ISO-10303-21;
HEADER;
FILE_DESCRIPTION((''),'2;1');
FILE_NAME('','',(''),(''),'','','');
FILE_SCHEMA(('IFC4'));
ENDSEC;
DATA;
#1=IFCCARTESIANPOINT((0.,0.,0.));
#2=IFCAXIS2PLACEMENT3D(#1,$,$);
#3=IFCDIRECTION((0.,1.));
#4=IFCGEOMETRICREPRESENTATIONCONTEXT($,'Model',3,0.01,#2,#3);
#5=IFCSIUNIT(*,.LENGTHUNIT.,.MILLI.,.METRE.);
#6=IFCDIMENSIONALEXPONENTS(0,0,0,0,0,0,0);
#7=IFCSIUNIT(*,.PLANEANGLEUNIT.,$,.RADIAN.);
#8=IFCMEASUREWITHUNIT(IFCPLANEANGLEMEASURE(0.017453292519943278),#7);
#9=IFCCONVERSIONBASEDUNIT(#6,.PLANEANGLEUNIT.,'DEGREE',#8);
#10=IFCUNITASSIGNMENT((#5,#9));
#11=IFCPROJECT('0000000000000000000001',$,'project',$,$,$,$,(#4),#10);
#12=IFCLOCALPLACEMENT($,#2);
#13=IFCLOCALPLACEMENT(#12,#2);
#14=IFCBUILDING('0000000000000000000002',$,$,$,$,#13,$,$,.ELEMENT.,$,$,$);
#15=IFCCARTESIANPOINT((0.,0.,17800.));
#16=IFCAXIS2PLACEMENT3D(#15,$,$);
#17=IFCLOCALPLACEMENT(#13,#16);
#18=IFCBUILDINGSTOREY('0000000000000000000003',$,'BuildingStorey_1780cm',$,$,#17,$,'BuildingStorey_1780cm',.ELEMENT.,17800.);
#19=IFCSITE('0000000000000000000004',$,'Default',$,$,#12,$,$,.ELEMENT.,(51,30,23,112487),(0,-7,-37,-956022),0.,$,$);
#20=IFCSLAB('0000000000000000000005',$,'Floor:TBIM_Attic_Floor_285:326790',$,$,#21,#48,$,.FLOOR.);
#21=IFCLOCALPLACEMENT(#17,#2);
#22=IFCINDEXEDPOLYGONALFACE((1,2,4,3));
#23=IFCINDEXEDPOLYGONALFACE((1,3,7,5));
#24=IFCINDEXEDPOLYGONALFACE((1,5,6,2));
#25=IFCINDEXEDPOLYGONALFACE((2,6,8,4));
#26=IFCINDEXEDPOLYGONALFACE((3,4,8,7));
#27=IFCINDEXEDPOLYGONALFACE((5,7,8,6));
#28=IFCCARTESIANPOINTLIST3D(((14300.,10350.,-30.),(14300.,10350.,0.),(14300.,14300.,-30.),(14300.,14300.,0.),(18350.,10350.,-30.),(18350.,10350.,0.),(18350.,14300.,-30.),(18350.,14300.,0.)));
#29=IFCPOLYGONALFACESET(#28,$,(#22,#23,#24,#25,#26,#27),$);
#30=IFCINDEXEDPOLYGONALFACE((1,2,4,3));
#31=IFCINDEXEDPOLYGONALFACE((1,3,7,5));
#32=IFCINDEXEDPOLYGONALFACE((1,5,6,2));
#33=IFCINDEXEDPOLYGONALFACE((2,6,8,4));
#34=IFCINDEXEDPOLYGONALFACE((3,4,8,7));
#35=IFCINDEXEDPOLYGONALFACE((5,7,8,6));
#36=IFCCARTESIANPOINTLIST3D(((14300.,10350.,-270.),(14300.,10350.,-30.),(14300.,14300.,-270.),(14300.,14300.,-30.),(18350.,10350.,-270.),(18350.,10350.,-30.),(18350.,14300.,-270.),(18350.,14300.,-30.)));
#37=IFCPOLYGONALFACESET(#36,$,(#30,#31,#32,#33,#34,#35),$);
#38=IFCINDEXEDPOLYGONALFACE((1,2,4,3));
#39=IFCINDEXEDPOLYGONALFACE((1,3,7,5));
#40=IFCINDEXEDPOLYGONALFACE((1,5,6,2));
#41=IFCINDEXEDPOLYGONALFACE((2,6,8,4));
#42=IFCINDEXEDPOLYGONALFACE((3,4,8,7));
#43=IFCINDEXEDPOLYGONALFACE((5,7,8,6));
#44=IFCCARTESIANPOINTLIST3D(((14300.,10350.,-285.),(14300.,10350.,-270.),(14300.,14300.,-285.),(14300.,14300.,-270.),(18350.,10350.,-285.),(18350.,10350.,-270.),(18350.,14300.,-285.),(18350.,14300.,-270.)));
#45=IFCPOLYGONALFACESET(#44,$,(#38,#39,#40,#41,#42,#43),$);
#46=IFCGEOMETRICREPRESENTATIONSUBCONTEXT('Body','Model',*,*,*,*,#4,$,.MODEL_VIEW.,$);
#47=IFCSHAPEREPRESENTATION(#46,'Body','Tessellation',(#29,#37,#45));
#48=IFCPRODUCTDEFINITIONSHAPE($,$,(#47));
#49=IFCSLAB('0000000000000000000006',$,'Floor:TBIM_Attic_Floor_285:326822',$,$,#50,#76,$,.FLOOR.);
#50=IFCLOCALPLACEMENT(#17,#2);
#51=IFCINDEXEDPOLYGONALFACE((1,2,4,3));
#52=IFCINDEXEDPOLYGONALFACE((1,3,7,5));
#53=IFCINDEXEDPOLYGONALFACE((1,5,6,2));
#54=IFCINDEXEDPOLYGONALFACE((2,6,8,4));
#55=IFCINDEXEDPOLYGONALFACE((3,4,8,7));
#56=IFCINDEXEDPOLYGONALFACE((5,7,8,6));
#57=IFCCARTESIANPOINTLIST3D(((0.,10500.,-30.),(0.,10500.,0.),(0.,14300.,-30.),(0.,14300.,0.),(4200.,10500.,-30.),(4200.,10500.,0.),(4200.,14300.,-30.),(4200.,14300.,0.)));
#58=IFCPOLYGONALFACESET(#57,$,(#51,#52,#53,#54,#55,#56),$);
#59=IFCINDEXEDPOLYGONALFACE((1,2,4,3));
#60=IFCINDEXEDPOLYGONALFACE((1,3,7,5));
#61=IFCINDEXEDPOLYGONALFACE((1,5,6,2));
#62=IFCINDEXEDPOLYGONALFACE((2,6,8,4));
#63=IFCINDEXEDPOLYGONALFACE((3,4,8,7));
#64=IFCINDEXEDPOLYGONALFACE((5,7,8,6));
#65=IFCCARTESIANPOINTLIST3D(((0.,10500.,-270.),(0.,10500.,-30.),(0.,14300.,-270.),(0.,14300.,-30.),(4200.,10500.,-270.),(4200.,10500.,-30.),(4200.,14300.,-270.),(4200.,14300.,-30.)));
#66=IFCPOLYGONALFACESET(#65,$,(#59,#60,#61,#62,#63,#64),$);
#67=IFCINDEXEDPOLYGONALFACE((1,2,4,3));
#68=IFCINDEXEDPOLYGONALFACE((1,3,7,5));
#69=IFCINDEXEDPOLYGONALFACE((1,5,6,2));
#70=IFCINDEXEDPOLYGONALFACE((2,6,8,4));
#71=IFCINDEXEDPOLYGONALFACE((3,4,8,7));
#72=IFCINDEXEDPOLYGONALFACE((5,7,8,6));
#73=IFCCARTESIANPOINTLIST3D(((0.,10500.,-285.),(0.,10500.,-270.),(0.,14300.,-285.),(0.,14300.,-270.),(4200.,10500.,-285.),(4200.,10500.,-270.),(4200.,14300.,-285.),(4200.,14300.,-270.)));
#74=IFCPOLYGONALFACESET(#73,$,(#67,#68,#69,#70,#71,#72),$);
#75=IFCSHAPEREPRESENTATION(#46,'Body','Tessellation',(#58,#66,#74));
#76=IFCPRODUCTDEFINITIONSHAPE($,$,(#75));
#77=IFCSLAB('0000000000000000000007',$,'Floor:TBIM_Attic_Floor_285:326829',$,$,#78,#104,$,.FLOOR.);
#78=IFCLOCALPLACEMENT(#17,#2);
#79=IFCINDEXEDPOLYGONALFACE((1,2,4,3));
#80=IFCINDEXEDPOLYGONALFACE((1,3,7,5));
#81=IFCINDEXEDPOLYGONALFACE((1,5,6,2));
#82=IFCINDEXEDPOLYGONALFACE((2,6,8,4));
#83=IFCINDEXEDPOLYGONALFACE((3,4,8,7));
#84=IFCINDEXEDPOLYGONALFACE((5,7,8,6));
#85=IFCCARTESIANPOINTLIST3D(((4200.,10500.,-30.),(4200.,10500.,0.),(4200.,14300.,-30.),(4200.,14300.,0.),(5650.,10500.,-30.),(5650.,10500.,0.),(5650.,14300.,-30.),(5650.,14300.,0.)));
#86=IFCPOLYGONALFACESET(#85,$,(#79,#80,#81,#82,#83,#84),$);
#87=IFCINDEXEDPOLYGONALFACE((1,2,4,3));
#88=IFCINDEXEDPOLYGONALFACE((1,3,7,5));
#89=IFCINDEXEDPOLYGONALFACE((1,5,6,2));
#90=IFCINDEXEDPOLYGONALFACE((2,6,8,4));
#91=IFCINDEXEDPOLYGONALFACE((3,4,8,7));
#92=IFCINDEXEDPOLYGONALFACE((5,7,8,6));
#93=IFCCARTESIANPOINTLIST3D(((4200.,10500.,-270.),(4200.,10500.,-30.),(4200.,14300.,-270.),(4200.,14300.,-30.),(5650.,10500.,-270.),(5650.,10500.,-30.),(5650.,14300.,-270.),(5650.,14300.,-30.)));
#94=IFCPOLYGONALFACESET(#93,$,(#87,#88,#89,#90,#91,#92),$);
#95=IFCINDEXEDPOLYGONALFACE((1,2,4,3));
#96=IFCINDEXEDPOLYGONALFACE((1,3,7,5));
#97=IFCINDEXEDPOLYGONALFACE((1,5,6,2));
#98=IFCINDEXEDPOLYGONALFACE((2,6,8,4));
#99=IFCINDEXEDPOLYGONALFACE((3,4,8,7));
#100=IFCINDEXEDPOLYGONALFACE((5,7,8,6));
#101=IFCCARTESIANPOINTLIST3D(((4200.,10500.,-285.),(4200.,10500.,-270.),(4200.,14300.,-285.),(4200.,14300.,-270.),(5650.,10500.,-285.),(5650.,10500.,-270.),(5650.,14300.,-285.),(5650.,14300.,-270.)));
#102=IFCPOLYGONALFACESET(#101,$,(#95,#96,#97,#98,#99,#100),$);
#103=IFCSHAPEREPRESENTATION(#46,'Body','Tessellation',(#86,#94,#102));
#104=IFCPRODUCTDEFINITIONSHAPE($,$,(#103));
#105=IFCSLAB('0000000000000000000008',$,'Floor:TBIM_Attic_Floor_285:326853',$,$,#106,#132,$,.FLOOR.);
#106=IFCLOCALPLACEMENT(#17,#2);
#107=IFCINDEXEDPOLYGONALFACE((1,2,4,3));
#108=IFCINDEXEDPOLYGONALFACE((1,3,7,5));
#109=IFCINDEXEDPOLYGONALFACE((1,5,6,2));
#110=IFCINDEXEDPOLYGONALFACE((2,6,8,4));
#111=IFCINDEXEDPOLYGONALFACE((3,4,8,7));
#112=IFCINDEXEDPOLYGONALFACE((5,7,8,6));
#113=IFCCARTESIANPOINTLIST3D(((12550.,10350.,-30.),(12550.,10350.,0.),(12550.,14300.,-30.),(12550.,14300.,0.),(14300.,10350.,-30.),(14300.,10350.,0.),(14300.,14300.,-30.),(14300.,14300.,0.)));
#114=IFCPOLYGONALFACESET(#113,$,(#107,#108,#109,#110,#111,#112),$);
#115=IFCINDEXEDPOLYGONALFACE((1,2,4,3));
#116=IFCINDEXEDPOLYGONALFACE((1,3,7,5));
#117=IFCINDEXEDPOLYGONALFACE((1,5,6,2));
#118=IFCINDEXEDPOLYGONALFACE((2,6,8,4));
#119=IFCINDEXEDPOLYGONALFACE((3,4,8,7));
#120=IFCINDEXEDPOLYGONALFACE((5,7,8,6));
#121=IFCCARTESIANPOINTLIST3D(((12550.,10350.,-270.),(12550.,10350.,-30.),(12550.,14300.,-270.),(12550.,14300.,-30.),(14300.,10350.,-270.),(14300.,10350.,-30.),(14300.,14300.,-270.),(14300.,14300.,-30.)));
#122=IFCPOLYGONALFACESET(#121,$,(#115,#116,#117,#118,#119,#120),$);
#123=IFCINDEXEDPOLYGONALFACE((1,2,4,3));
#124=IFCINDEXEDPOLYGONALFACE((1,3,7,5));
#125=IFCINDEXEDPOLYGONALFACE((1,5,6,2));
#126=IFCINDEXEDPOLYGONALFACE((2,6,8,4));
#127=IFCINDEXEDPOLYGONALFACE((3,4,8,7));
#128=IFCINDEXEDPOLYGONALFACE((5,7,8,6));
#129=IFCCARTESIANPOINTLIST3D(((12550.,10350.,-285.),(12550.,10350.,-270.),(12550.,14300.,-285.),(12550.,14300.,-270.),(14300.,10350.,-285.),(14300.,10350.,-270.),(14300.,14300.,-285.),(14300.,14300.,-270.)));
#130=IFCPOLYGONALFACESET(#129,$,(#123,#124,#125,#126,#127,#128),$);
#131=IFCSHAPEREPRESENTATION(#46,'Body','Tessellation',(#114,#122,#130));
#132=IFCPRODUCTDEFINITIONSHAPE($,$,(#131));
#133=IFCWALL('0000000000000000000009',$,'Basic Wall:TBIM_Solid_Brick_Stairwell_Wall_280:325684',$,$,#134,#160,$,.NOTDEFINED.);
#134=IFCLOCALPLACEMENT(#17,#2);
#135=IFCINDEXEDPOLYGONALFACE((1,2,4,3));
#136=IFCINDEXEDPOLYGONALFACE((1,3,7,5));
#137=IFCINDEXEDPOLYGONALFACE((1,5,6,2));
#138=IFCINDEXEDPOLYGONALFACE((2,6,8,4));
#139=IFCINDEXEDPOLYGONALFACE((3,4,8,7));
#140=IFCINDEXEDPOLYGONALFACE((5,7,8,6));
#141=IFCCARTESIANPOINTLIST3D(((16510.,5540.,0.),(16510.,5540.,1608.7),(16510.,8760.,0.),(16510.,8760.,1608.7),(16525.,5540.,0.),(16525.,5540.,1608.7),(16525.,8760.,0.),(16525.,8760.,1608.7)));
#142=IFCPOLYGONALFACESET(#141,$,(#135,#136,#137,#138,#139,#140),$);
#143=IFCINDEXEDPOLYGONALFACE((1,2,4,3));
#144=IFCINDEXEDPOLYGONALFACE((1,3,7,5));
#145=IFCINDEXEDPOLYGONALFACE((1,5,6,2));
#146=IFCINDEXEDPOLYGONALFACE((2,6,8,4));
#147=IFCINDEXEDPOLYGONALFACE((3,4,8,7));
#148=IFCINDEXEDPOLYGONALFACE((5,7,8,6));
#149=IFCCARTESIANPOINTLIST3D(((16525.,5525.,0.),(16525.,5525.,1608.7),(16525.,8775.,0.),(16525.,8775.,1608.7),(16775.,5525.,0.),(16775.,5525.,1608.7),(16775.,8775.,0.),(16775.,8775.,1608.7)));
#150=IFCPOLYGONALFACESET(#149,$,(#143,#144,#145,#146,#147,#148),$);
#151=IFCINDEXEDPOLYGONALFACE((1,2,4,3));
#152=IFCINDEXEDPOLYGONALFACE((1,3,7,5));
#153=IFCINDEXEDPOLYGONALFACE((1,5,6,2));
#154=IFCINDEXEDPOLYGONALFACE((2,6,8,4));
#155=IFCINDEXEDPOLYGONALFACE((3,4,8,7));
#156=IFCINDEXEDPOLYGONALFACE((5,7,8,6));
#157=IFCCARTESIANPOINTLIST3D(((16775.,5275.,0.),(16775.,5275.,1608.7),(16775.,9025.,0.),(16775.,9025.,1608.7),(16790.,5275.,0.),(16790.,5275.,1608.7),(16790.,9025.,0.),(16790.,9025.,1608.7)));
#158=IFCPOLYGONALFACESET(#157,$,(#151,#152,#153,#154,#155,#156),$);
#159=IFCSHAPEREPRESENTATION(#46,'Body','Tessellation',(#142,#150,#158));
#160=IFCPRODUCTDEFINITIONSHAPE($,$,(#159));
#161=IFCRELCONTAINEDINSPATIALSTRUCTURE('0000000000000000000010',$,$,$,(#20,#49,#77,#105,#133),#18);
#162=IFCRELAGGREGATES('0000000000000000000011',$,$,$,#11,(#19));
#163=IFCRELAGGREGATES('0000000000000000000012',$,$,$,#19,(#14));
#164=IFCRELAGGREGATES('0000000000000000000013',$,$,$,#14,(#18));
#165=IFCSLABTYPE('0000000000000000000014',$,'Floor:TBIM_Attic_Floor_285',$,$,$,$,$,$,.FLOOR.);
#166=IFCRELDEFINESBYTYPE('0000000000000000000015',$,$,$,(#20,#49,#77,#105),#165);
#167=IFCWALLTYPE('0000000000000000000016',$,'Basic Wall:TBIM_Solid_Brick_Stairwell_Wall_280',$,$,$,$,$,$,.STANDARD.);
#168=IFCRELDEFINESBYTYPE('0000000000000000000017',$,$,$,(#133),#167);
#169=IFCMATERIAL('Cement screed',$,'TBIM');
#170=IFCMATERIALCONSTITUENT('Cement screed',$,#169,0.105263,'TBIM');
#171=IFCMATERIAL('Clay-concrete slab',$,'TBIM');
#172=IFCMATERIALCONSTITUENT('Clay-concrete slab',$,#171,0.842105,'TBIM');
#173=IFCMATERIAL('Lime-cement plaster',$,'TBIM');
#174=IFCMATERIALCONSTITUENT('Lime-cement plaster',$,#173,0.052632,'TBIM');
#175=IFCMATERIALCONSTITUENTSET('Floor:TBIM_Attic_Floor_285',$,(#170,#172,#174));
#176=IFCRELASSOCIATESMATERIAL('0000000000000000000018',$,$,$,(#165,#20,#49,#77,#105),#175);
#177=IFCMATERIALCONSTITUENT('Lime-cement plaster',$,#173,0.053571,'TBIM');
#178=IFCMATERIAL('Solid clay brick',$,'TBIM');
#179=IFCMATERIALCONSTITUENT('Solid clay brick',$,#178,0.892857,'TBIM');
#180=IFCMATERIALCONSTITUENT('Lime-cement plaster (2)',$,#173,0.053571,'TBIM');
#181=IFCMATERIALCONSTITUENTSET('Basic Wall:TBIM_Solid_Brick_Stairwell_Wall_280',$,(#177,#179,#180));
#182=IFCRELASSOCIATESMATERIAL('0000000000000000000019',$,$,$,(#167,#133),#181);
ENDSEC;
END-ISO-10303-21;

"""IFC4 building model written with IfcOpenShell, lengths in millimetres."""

from ifc_helpers import new_model, entity, si_unit, converted_unit, direction, frame, origin, place, context, subcontext, project, spatial, indexed_curve, outline, extrude, material, constituent, constituent_set, type_object, element, save


model = new_model("IFC4")

# Units and contexts
model_context = context("Model", 3, precision=0.01, world=origin(), true_north=direction((0.0, 1.0)))
body_context = subcontext(model_context, "Body", "Model", "MODEL_VIEW")
ifc_project = project(units=[si_unit("LENGTHUNIT", "METRE", prefix="MILLI"), converted_unit("PLANEANGLEUNIT", "DEGREE", entity("IfcPlaneAngleMeasure", 0.017453292519943278), si_unit("PLANEANGLEUNIT", "RADIAN"), dimensions=[0, 0, 0, 0, 0, 0, 0])], contexts=[model_context])

# Site, building, storey
site_placement = place(None, origin())
site = spatial("IfcSite", under=ifc_project, at=site_placement, Name="Default", CompositionType="ELEMENT", RefLatitude=(51, 30, 23, 112487), RefLongitude=(0, -7, -37, -956022), RefElevation=0.0)
building_placement = place(site_placement, origin())
building = spatial("IfcBuilding", under=site, at=building_placement, CompositionType="ELEMENT")
storey_placement = place(building_placement, frame((0.0, 0.0, 17800.0)))
storey = spatial("IfcBuildingStorey", under=building, at=storey_placement, Name="BuildingStorey_1780cm", LongName="BuildingStorey_1780cm", CompositionType="ELEMENT", Elevation=17800.0)

# Slabs
ifc_material_1 = material(Name="Cement screed", Category="TBIM")
ifc_material_2 = material(Name="Clay-concrete slab", Category="TBIM")
ifc_material_3 = material(Name="Lime-cement plaster", Category="TBIM")
ifc_constituent_1 = constituent(ifc_material_1, Name="Cement screed", Category="TBIM", fraction=0.105263)
ifc_constituent_2 = constituent(ifc_material_2, Name="Clay-concrete slab", Category="TBIM", fraction=0.842105)
ifc_constituent_3 = constituent(ifc_material_3, Name="Lime-cement plaster", Category="TBIM", fraction=0.052632)
ifc_constituent_set_1 = constituent_set(constituents=[ifc_constituent_1, ifc_constituent_2, ifc_constituent_3], Name="Floor:TBIM_Attic_Floor_285")
slab_type_1 = type_object("IfcSlabType", Name="Floor:TBIM_Attic_Floor_285", PredefinedType="FLOOR", material=ifc_constituent_set_1)
slab_1_placement = place(storey_placement, origin())
element("IfcSlab", 1, at=slab_1_placement, inside=storey, type_object=slab_type_1, material=ifc_constituent_set_1, Name="Floor:TBIM_Attic_Floor_285:326790", PredefinedType="FLOOR", context=body_context, shape_type="SweptSolid", body=[
    extrude(outline(indexed_curve([(-2025.0, -1975.0), (2025.0, -1975.0), (2025.0, 1975.0), (-2025.0, 1975.0), (-2025.0, -1975.0)], self_intersect=False)), frame((16325.0, 12325.0, -30.0), z_axis=(0.0, 0.0, 1.0), x_axis=(-1.0, 0.0, 0.0)), (0.0, 0.0, 1.0), 30.0),
    extrude(outline(indexed_curve([(-2025.0, -1975.0), (2025.0, -1975.0), (2025.0, 1975.0), (-2025.0, 1975.0), (-2025.0, -1975.0)], self_intersect=False)), frame((16325.0, 12325.0, -270.0), z_axis=(0.0, 0.0, 1.0), x_axis=(-1.0, 0.0, 0.0)), (0.0, 0.0, 1.0), 240.0),
    extrude(outline(indexed_curve([(-2025.0, -1975.0), (2025.0, -1975.0), (2025.0, 1975.0), (-2025.0, 1975.0), (-2025.0, -1975.0)], self_intersect=False)), frame((16325.0, 12325.0, -285.0), z_axis=(0.0, 0.0, 1.0), x_axis=(-1.0, 0.0, 0.0)), (0.0, 0.0, 1.0), 15.0),
])
slab_2_placement = place(storey_placement, origin())
element("IfcSlab", 2, at=slab_2_placement, inside=storey, type_object=slab_type_1, material=ifc_constituent_set_1, Name="Floor:TBIM_Attic_Floor_285:326822", PredefinedType="FLOOR", context=body_context, shape_type="SweptSolid", body=[
    extrude(outline(indexed_curve([(-2100.0, -1900.0), (2100.0, -1900.0), (2100.0, 1900.0), (-2100.0, 1900.0), (-2100.0, -1900.0)], self_intersect=False)), frame((2100.0, 12400.0, -30.0), z_axis=(0.0, 0.0, 1.0), x_axis=(-1.0, 0.0, 0.0)), (0.0, 0.0, 1.0), 30.0),
    extrude(outline(indexed_curve([(-2100.0, -1900.0), (2100.0, -1900.0), (2100.0, 1900.0), (-2100.0, 1900.0), (-2100.0, -1900.0)], self_intersect=False)), frame((2100.0, 12400.0, -270.0), z_axis=(0.0, 0.0, 1.0), x_axis=(-1.0, 0.0, 0.0)), (0.0, 0.0, 1.0), 240.0),
    extrude(outline(indexed_curve([(-2100.0, -1900.0), (2100.0, -1900.0), (2100.0, 1900.0), (-2100.0, 1900.0), (-2100.0, -1900.0)], self_intersect=False)), frame((2100.0, 12400.0, -285.0), z_axis=(0.0, 0.0, 1.0), x_axis=(-1.0, 0.0, 0.0)), (0.0, 0.0, 1.0), 15.0),
])
slab_3_placement = place(storey_placement, origin())
element("IfcSlab", 3, at=slab_3_placement, inside=storey, type_object=slab_type_1, material=ifc_constituent_set_1, Name="Floor:TBIM_Attic_Floor_285:326829", PredefinedType="FLOOR", context=body_context, shape_type="SweptSolid", body=[
    extrude(outline(indexed_curve([(-725.0, -1900.0), (725.0, -1900.0), (725.0, 1900.0), (-725.0, 1900.0), (-725.0, -1900.0)], self_intersect=False)), frame((4925.0, 12400.0, -30.0), z_axis=(0.0, 0.0, 1.0), x_axis=(-1.0, 0.0, 0.0)), (0.0, 0.0, 1.0), 30.0),
    extrude(outline(indexed_curve([(-725.0, -1900.0), (725.0, -1900.0), (725.0, 1900.0), (-725.0, 1900.0), (-725.0, -1900.0)], self_intersect=False)), frame((4925.0, 12400.0, -270.0), z_axis=(0.0, 0.0, 1.0), x_axis=(-1.0, 0.0, 0.0)), (0.0, 0.0, 1.0), 240.0),
    extrude(outline(indexed_curve([(-725.0, -1900.0), (725.0, -1900.0), (725.0, 1900.0), (-725.0, 1900.0), (-725.0, -1900.0)], self_intersect=False)), frame((4925.0, 12400.0, -285.0), z_axis=(0.0, 0.0, 1.0), x_axis=(-1.0, 0.0, 0.0)), (0.0, 0.0, 1.0), 15.0),
])
slab_4_placement = place(storey_placement, origin())
element("IfcSlab", 4, at=slab_4_placement, inside=storey, type_object=slab_type_1, material=ifc_constituent_set_1, Name="Floor:TBIM_Attic_Floor_285:326853", PredefinedType="FLOOR", context=body_context, shape_type="SweptSolid", body=[
    extrude(outline(indexed_curve([(-875.0, -1975.0), (875.0, -1975.0), (875.0, 1975.0), (-875.0, 1975.0), (-875.0, -1975.0)], self_intersect=False)), frame((13425.0, 12325.0, -30.0), z_axis=(0.0, 0.0, 1.0), x_axis=(-1.0, 0.0, 0.0)), (0.0, 0.0, 1.0), 30.0),
    extrude(outline(indexed_curve([(-875.0, -1975.0), (875.0, -1975.0), (875.0, 1975.0), (-875.0, 1975.0), (-875.0, -1975.0)], self_intersect=False)), frame((13425.0, 12325.0, -270.0), z_axis=(0.0, 0.0, 1.0), x_axis=(-1.0, 0.0, 0.0)), (0.0, 0.0, 1.0), 240.0),
    extrude(outline(indexed_curve([(-875.0, -1975.0), (875.0, -1975.0), (875.0, 1975.0), (-875.0, 1975.0), (-875.0, -1975.0)], self_intersect=False)), frame((13425.0, 12325.0, -285.0), z_axis=(0.0, 0.0, 1.0), x_axis=(-1.0, 0.0, 0.0)), (0.0, 0.0, 1.0), 15.0),
])

# Wall
ifc_constituent_4 = constituent(ifc_material_3, Name="Lime-cement plaster", Category="TBIM", fraction=0.053571)
ifc_material_4 = material(Name="Solid clay brick", Category="TBIM")
ifc_constituent_5 = constituent(ifc_material_4, Name="Solid clay brick", Category="TBIM", fraction=0.892857)
ifc_constituent_6 = constituent(ifc_material_3, Name="Lime-cement plaster (2)", Category="TBIM", fraction=0.053571)
ifc_constituent_set_2 = constituent_set(constituents=[ifc_constituent_4, ifc_constituent_5, ifc_constituent_6], Name="Basic Wall:TBIM_Solid_Brick_Stairwell_Wall_280")
wall_type = type_object("IfcWallType", Name="Basic Wall:TBIM_Solid_Brick_Stairwell_Wall_280", PredefinedType="STANDARD", material=ifc_constituent_set_2)
wall_1_placement = place(storey_placement, frame((16650.0, 5540.0, 0.0), z_axis=(0.0, 0.0, 1.0), x_axis=(0.0, 1.0, 0.0)))
element("IfcWall", 5, at=wall_1_placement, inside=storey, type_object=wall_type, material=ifc_constituent_set_2, Name="Basic Wall:TBIM_Solid_Brick_Stairwell_Wall_280:325684", PredefinedType="NOTDEFINED", context=body_context, shape_type="SweptSolid", body=[
    extrude(outline(indexed_curve([(-7.5, -1610.0), (7.5, -1610.0), (7.5, 1610.0), (-7.5, 1610.0), (-7.5, -1610.0)], self_intersect=False)), frame((1610.0, 132.5, 0.0), z_axis=(0.0, 0.0, 1.0), x_axis=(0.0, -1.0, 0.0)), (0.0, 0.0, 1.0), 1608.7),
    extrude(outline(indexed_curve([(-1625.0, -125.0), (1625.0, -125.0), (1625.0, 125.0), (-1625.0, 125.0), (-1625.0, -125.0)], self_intersect=False)), frame((1610.0, 0.0, 0.0)), (0.0, 0.0, 1.0), 1608.7),
    extrude(outline(indexed_curve([(-7.5, -1875.0), (7.5, -1875.0), (7.5, 1875.0), (-7.5, 1875.0), (-7.5, -1875.0)], self_intersect=False)), frame((1610.0, -132.5, 0.0), z_axis=(0.0, 0.0, 1.0), x_axis=(0.0, 1.0, 0.0)), (0.0, 0.0, 1.0), 1608.7),
])

save(model, "model.ifc")
